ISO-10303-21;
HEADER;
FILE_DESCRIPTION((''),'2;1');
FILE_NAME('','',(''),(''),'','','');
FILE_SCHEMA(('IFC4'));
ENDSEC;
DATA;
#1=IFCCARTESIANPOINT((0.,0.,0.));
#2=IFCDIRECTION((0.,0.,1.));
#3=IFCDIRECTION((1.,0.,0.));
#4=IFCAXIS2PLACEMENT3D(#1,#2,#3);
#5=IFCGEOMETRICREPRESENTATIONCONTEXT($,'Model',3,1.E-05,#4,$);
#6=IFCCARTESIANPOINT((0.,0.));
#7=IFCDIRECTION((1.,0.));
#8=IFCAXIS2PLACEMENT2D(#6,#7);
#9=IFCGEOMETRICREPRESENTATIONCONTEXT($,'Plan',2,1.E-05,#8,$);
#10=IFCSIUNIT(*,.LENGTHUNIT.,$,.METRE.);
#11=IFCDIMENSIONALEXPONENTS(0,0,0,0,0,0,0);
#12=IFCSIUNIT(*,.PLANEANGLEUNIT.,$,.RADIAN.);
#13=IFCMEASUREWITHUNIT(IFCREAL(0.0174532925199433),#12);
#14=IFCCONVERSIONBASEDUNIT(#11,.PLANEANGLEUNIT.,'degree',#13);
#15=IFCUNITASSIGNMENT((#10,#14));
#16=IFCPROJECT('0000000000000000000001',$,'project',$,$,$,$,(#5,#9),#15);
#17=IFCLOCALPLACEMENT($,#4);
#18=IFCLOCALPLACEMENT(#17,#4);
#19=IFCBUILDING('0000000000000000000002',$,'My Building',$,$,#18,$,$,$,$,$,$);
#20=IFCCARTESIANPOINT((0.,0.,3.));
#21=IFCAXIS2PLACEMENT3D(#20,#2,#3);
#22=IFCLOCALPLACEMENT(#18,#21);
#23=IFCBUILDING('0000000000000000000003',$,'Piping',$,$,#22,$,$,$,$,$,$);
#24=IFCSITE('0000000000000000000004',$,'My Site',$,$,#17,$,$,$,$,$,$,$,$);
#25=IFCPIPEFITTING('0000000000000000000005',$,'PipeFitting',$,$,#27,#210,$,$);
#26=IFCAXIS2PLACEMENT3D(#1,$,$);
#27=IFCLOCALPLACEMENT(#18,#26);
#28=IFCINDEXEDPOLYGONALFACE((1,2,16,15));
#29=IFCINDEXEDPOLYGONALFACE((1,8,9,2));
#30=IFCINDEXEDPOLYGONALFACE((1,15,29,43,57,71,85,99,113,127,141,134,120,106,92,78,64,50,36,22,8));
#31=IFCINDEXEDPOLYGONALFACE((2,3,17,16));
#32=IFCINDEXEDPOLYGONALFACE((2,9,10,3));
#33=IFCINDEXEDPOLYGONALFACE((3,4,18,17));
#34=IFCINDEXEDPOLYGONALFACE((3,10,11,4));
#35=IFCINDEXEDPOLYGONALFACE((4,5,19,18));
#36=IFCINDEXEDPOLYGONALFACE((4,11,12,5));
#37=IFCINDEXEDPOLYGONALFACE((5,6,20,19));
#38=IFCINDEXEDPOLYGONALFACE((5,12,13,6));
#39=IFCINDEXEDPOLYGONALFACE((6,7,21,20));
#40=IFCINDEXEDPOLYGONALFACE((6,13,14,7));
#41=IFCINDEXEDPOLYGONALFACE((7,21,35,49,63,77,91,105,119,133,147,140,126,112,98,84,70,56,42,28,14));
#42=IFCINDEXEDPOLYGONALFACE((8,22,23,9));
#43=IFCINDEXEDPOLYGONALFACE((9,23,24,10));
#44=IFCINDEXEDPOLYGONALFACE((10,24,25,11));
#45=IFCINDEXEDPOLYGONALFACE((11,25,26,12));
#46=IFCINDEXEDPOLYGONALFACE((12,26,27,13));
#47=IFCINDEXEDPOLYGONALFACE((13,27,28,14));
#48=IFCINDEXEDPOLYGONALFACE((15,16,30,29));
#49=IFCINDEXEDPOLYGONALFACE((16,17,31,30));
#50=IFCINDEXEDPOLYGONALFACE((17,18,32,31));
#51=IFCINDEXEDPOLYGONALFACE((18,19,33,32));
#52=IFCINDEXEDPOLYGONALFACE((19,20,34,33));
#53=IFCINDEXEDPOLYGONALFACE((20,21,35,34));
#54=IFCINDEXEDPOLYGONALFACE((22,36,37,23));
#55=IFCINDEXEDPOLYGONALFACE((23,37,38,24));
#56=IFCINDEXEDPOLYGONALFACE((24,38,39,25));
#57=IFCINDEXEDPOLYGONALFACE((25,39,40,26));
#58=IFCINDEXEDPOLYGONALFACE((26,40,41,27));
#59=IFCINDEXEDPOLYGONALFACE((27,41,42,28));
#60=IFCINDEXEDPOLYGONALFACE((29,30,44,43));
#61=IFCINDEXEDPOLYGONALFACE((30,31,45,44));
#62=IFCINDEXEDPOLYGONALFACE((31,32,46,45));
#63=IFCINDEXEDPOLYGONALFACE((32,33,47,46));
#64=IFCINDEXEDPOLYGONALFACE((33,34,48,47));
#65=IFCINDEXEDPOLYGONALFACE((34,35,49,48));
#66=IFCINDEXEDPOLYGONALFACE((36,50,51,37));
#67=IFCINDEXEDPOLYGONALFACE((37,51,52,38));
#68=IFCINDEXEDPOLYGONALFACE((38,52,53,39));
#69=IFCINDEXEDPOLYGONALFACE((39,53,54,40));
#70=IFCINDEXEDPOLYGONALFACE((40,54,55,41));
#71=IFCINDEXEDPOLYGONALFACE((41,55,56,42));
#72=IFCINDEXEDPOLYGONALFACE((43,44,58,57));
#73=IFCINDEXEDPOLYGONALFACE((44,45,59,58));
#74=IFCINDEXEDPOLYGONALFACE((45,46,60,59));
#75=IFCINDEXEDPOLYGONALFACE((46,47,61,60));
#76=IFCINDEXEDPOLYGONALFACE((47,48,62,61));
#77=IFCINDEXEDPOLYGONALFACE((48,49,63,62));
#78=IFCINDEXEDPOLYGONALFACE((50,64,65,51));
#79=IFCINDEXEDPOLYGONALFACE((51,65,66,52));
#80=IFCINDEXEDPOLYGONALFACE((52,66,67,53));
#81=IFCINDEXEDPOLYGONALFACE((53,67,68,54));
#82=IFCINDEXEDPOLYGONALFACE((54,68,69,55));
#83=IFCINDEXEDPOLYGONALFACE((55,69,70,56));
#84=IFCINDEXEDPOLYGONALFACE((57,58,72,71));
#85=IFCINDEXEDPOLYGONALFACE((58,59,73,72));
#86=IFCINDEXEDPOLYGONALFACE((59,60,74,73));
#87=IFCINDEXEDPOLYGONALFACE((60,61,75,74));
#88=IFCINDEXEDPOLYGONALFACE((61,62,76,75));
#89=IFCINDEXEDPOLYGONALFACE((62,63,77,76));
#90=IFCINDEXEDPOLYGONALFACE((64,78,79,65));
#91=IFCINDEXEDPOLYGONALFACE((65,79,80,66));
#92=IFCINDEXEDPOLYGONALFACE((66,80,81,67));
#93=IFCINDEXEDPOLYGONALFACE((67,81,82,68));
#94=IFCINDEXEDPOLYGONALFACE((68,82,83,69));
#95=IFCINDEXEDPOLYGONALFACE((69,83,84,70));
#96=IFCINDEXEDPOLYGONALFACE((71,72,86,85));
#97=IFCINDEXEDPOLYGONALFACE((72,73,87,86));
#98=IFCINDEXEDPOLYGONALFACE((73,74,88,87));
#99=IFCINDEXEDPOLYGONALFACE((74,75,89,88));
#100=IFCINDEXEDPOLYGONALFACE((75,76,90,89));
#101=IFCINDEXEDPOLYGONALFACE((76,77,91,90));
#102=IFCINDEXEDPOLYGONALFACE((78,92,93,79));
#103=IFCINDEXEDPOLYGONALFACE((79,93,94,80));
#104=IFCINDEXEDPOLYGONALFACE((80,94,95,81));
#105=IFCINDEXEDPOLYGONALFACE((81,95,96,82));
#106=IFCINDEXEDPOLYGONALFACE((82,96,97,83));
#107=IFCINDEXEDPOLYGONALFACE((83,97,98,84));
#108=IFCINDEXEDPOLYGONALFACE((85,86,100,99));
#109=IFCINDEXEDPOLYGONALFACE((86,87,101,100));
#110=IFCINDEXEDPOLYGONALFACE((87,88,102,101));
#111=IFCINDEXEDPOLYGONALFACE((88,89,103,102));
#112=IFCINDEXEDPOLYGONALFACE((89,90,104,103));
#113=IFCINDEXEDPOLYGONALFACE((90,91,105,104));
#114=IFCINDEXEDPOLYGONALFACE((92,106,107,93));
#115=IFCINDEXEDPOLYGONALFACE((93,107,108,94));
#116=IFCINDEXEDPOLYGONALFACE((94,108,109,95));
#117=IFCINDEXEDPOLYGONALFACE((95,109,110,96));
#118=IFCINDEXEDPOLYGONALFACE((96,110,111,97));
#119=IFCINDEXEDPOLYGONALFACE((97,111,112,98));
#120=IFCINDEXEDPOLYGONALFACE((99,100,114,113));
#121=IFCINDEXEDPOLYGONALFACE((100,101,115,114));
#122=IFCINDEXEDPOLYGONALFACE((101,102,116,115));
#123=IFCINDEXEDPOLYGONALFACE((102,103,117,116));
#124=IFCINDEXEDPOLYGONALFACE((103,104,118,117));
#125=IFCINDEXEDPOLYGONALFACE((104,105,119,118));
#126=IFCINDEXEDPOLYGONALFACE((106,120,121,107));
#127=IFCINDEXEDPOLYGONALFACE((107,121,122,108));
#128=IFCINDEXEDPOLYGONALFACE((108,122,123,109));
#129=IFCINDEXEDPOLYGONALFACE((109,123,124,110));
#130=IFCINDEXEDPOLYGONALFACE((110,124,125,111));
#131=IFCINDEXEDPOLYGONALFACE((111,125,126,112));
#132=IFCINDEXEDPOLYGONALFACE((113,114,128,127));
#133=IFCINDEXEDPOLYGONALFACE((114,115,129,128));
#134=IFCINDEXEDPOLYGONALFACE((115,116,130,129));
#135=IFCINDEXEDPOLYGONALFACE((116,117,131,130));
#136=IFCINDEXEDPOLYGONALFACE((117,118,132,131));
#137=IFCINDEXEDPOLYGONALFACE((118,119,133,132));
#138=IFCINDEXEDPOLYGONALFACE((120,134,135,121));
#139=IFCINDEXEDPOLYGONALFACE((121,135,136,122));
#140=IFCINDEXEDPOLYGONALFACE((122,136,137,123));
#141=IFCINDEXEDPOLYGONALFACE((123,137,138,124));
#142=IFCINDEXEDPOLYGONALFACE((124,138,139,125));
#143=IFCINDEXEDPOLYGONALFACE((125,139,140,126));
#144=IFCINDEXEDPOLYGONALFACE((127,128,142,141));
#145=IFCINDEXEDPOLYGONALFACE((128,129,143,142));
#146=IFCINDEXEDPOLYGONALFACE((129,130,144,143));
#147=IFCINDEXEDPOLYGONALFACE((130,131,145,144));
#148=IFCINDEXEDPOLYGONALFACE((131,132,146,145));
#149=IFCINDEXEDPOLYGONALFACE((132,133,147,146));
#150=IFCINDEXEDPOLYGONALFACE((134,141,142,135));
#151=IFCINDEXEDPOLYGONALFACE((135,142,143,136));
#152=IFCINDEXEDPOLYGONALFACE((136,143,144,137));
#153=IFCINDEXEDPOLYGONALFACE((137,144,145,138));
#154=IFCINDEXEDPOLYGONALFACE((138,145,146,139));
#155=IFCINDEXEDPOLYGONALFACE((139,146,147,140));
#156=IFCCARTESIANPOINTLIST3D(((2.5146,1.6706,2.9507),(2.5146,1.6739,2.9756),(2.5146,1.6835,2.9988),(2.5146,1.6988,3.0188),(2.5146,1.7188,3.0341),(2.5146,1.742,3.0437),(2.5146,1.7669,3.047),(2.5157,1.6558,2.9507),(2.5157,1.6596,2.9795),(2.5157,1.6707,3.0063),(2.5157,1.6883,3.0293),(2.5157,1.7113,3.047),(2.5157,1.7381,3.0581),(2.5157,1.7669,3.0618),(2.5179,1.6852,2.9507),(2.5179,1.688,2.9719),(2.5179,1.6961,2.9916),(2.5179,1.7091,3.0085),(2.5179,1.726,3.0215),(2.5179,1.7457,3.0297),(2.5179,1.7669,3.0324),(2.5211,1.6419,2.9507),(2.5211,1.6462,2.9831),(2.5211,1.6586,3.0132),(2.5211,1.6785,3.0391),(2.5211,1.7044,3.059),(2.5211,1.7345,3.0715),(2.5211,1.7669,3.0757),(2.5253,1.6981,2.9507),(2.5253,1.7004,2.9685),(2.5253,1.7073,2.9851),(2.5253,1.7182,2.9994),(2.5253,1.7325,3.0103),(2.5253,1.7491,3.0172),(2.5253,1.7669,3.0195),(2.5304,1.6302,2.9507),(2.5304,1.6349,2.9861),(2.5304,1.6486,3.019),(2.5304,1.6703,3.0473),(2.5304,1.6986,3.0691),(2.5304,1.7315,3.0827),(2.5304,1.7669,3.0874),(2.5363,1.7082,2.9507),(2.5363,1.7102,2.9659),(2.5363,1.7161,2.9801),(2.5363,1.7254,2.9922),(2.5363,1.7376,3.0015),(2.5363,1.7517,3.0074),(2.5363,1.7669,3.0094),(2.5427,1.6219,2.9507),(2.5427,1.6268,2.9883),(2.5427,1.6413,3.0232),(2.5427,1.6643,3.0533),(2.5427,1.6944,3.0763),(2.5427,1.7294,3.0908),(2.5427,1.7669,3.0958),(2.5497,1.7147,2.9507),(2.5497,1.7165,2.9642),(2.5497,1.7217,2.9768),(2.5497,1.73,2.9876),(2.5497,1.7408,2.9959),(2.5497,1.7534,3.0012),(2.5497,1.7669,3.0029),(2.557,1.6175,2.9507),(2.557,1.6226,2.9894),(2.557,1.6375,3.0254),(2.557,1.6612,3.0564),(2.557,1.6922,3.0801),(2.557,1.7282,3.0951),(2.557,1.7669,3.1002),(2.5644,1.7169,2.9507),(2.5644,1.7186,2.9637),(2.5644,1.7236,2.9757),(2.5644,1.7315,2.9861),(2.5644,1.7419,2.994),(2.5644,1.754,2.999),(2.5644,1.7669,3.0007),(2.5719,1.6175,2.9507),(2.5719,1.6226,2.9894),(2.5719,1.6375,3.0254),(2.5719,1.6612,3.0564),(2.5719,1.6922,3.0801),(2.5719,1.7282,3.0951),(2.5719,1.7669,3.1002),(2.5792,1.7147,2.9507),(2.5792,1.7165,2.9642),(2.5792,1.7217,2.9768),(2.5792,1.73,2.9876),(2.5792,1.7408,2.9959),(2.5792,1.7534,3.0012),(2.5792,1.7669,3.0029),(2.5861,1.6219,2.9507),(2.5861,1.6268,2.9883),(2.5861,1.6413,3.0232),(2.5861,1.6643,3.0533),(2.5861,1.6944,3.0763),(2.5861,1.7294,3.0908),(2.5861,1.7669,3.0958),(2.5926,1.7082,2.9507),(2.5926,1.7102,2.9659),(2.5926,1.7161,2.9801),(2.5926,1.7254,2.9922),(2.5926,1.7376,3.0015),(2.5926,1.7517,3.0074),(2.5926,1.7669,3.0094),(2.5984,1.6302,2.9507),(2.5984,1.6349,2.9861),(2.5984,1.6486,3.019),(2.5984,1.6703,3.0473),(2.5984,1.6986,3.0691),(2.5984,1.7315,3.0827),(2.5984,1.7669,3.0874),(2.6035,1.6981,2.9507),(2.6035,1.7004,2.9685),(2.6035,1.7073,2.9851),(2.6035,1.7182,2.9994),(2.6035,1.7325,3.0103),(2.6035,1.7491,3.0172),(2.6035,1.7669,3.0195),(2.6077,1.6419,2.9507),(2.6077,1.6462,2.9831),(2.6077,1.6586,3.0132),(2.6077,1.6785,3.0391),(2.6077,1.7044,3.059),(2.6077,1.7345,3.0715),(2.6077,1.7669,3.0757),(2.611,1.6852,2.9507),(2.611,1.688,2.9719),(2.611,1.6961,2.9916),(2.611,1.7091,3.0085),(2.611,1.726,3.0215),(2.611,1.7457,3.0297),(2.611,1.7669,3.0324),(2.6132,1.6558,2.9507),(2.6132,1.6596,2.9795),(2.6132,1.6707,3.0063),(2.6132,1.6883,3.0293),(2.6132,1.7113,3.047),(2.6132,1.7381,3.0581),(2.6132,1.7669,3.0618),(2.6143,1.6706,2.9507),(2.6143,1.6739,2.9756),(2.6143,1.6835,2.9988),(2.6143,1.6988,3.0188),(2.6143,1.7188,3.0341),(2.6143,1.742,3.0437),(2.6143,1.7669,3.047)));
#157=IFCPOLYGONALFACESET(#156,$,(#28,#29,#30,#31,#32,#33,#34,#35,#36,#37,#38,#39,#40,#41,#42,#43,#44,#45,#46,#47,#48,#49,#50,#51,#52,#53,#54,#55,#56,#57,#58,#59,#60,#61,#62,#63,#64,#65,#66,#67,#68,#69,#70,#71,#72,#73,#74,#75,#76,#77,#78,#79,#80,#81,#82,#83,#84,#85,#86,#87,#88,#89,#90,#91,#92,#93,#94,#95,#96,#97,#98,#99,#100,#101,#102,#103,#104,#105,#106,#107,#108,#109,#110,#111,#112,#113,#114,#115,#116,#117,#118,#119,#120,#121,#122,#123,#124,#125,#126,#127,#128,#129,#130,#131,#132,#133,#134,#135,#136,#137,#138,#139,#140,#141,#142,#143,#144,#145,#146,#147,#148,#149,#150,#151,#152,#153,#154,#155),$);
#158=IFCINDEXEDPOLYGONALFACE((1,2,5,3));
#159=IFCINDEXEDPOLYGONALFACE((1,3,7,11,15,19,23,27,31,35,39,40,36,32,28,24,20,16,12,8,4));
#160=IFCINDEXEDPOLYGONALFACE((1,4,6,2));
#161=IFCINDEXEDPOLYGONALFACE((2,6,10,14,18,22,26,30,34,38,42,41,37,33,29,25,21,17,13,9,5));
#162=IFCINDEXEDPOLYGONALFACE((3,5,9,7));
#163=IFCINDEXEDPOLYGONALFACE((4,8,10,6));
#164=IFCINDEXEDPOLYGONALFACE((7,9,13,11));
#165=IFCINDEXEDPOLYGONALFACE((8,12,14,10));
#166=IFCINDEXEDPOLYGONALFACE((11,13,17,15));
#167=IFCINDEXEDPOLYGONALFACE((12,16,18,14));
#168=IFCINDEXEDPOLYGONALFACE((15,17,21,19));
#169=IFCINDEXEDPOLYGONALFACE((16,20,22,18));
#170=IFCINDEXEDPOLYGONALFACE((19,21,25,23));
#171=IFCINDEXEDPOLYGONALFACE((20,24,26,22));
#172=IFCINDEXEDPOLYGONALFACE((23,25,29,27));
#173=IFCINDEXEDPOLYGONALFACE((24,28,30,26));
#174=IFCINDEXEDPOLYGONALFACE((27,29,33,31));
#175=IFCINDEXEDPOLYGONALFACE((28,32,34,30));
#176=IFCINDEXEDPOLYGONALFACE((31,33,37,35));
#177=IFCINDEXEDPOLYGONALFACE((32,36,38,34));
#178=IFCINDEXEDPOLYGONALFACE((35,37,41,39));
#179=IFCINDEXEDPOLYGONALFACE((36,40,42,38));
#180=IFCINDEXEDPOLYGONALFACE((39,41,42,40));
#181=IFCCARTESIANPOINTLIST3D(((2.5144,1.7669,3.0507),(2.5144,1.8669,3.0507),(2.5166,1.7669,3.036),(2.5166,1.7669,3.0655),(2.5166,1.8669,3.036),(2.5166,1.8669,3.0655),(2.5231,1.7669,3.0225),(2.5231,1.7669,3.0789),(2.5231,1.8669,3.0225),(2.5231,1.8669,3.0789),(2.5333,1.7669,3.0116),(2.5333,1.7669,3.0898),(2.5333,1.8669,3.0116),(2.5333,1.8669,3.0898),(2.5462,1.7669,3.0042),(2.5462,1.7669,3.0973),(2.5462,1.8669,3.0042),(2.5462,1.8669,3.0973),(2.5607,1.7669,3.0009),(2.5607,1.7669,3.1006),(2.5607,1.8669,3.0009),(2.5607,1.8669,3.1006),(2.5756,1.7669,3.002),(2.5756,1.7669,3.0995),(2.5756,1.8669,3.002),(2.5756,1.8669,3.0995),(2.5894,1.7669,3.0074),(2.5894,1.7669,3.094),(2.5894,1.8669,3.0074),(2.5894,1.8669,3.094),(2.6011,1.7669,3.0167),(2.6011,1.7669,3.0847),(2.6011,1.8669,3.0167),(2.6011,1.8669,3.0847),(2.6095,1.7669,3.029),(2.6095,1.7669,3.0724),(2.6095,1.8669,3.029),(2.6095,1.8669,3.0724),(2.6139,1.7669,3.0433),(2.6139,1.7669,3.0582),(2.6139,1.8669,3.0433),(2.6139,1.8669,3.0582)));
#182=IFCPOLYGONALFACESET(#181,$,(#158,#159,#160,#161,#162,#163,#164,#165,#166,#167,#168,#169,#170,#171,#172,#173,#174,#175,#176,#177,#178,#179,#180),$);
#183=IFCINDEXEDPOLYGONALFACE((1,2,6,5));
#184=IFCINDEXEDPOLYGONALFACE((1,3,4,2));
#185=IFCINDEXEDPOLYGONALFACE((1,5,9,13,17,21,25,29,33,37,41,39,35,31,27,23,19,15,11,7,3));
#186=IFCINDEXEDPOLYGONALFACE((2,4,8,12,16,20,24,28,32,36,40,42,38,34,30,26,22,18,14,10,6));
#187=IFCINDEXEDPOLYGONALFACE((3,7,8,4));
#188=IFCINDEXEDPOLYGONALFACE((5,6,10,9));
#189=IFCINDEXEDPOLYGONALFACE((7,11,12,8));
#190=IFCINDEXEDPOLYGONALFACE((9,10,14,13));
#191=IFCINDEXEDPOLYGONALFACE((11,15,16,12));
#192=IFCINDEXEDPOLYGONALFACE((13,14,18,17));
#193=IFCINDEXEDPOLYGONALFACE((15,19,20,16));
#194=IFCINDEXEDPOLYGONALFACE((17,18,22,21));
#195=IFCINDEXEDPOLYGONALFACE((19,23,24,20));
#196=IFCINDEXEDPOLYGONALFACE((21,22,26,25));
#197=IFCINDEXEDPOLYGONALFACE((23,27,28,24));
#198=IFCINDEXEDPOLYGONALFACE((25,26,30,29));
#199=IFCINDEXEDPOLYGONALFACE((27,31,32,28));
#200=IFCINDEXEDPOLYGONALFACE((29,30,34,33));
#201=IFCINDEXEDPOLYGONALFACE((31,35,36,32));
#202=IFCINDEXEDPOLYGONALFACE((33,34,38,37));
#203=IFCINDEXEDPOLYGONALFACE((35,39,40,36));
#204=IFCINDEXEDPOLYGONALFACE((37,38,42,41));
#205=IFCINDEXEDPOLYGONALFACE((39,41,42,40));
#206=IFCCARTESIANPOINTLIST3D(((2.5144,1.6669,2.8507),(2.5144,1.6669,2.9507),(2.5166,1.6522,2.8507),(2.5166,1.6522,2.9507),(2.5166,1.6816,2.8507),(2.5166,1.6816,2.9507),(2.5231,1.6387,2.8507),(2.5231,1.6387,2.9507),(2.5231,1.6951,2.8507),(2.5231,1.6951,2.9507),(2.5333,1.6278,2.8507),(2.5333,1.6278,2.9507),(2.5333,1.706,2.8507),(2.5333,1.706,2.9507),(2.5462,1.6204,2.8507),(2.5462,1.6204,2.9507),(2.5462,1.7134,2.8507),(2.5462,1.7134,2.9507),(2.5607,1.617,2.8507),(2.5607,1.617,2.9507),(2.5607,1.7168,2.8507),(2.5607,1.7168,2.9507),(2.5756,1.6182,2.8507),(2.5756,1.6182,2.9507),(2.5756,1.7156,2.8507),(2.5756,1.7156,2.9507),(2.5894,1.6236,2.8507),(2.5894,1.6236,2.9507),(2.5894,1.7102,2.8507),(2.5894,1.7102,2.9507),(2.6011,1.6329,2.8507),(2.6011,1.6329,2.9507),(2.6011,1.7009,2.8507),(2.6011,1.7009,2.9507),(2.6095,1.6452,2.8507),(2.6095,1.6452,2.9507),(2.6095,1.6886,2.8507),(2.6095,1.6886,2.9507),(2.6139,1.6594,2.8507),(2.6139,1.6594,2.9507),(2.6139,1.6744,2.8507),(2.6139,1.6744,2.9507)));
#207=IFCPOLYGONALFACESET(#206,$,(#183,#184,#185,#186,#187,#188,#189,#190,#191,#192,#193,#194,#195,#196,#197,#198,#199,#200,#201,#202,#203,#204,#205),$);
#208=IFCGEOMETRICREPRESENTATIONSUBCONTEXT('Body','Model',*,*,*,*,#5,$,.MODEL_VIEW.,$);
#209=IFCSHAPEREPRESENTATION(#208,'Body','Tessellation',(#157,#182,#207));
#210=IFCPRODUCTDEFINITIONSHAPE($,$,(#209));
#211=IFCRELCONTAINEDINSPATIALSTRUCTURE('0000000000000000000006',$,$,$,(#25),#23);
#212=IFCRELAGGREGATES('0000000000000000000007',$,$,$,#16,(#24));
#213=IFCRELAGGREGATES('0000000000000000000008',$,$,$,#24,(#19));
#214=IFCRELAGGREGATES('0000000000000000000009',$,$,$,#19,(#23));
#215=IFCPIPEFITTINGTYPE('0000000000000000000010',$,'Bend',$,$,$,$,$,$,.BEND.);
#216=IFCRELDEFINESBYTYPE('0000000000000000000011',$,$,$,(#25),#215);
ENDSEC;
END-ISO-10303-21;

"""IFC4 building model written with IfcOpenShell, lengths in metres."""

from ifc_helpers import new_model, entity, si_unit, converted_unit, frame, origin_with_axes, origin_2d_with_axis, place, context, subcontext, project, spatial, circle, extrude, source, transform, mapped, type_object, type_shapes, element, save


model = new_model("IFC4")

# Units and contexts
model_context = context("Model", 3, precision=1e-05, world=origin_with_axes())
plan_context = context("Plan", 2, precision=1e-05, world=origin_2d_with_axis())
body_context = subcontext(model_context, "Body", "Model", "MODEL_VIEW")
ifc_project = project(units=[si_unit("LENGTHUNIT", "METRE"), converted_unit("PLANEANGLEUNIT", "degree", entity("IfcReal", 0.0174532925199433), si_unit("PLANEANGLEUNIT", "RADIAN"), dimensions=[0, 0, 0, 0, 0, 0, 0])], contexts=[model_context, plan_context])

# Site, buildings
site_placement = place(None, origin_with_axes())
site = spatial("IfcSite", under=ifc_project, at=site_placement, Name="My Site")
building_1_placement = place(site_placement, origin_with_axes())
building_1 = spatial("IfcBuilding", under=site, at=building_1_placement, Name="My Building")
building_2_placement = place(building_1_placement, frame((0.0, 0.0, 3.0), z_axis=(0.0, 0.0, 1.0), x_axis=(1.0, 0.0, 0.0)))
building_2 = spatial("IfcBuilding", under=building_1, at=building_2_placement, Name="Piping")

# Pipe fitting
pipe_fitting_type_1 = type_object("IfcPipeFittingType", Name="Bend", PredefinedType="BEND")
shared_shape = source(origin_with_axes(), body_context, "Body", "SolidModel", [
    entity("IfcSweptDiskSolid", entity("IfcIndexedPolyCurve", entity("IfcCartesianPointList3D", [[0.0, 0.0, 0.1], [0.0, 0.0293, 0.1707], [0.0, 0.1, 0.2]]), [entity("IfcArcIndex", [1, 2, 3])]), 0.05),
    extrude(circle(Radius=0.05), origin_with_axes(), (0.0, 0.0, 1.0), 0.1),
    extrude(circle(Radius=0.05), frame((0.0, 0.1, 0.2), z_axis=(0.0, 1.0, 0.0), x_axis=(1.0, 0.0, 0.0)), (0.0, 0.0, 1.0), 0.1),
])
type_shapes(pipe_fitting_type_1, [shared_shape])
for number, where, z_axis, x_axis, name in (
    (1, (2.5644, 1.8669, 0.0507), (0.0, -1.0, 0.0), (-1.0, 0.0, 0.0), "PipeFitting"),
):
    element("IfcPipeFitting", number, at=place(building_2_placement, frame(where, z_axis=z_axis, x_axis=x_axis)), inside=building_2, type_object=pipe_fitting_type_1, Name=name, context=body_context, shape_type="MappedRepresentation", body=[
        mapped(shared_shape, transform((0.0, 0.0, 0.0), x_axis=(1.0, 0.0, 0.0), y_axis=(0.0, 1.0, 0.0), z_axis=(0.0, 0.0, 1.0), scale=1.0)),
    ])

save(model, "model.ifc")
